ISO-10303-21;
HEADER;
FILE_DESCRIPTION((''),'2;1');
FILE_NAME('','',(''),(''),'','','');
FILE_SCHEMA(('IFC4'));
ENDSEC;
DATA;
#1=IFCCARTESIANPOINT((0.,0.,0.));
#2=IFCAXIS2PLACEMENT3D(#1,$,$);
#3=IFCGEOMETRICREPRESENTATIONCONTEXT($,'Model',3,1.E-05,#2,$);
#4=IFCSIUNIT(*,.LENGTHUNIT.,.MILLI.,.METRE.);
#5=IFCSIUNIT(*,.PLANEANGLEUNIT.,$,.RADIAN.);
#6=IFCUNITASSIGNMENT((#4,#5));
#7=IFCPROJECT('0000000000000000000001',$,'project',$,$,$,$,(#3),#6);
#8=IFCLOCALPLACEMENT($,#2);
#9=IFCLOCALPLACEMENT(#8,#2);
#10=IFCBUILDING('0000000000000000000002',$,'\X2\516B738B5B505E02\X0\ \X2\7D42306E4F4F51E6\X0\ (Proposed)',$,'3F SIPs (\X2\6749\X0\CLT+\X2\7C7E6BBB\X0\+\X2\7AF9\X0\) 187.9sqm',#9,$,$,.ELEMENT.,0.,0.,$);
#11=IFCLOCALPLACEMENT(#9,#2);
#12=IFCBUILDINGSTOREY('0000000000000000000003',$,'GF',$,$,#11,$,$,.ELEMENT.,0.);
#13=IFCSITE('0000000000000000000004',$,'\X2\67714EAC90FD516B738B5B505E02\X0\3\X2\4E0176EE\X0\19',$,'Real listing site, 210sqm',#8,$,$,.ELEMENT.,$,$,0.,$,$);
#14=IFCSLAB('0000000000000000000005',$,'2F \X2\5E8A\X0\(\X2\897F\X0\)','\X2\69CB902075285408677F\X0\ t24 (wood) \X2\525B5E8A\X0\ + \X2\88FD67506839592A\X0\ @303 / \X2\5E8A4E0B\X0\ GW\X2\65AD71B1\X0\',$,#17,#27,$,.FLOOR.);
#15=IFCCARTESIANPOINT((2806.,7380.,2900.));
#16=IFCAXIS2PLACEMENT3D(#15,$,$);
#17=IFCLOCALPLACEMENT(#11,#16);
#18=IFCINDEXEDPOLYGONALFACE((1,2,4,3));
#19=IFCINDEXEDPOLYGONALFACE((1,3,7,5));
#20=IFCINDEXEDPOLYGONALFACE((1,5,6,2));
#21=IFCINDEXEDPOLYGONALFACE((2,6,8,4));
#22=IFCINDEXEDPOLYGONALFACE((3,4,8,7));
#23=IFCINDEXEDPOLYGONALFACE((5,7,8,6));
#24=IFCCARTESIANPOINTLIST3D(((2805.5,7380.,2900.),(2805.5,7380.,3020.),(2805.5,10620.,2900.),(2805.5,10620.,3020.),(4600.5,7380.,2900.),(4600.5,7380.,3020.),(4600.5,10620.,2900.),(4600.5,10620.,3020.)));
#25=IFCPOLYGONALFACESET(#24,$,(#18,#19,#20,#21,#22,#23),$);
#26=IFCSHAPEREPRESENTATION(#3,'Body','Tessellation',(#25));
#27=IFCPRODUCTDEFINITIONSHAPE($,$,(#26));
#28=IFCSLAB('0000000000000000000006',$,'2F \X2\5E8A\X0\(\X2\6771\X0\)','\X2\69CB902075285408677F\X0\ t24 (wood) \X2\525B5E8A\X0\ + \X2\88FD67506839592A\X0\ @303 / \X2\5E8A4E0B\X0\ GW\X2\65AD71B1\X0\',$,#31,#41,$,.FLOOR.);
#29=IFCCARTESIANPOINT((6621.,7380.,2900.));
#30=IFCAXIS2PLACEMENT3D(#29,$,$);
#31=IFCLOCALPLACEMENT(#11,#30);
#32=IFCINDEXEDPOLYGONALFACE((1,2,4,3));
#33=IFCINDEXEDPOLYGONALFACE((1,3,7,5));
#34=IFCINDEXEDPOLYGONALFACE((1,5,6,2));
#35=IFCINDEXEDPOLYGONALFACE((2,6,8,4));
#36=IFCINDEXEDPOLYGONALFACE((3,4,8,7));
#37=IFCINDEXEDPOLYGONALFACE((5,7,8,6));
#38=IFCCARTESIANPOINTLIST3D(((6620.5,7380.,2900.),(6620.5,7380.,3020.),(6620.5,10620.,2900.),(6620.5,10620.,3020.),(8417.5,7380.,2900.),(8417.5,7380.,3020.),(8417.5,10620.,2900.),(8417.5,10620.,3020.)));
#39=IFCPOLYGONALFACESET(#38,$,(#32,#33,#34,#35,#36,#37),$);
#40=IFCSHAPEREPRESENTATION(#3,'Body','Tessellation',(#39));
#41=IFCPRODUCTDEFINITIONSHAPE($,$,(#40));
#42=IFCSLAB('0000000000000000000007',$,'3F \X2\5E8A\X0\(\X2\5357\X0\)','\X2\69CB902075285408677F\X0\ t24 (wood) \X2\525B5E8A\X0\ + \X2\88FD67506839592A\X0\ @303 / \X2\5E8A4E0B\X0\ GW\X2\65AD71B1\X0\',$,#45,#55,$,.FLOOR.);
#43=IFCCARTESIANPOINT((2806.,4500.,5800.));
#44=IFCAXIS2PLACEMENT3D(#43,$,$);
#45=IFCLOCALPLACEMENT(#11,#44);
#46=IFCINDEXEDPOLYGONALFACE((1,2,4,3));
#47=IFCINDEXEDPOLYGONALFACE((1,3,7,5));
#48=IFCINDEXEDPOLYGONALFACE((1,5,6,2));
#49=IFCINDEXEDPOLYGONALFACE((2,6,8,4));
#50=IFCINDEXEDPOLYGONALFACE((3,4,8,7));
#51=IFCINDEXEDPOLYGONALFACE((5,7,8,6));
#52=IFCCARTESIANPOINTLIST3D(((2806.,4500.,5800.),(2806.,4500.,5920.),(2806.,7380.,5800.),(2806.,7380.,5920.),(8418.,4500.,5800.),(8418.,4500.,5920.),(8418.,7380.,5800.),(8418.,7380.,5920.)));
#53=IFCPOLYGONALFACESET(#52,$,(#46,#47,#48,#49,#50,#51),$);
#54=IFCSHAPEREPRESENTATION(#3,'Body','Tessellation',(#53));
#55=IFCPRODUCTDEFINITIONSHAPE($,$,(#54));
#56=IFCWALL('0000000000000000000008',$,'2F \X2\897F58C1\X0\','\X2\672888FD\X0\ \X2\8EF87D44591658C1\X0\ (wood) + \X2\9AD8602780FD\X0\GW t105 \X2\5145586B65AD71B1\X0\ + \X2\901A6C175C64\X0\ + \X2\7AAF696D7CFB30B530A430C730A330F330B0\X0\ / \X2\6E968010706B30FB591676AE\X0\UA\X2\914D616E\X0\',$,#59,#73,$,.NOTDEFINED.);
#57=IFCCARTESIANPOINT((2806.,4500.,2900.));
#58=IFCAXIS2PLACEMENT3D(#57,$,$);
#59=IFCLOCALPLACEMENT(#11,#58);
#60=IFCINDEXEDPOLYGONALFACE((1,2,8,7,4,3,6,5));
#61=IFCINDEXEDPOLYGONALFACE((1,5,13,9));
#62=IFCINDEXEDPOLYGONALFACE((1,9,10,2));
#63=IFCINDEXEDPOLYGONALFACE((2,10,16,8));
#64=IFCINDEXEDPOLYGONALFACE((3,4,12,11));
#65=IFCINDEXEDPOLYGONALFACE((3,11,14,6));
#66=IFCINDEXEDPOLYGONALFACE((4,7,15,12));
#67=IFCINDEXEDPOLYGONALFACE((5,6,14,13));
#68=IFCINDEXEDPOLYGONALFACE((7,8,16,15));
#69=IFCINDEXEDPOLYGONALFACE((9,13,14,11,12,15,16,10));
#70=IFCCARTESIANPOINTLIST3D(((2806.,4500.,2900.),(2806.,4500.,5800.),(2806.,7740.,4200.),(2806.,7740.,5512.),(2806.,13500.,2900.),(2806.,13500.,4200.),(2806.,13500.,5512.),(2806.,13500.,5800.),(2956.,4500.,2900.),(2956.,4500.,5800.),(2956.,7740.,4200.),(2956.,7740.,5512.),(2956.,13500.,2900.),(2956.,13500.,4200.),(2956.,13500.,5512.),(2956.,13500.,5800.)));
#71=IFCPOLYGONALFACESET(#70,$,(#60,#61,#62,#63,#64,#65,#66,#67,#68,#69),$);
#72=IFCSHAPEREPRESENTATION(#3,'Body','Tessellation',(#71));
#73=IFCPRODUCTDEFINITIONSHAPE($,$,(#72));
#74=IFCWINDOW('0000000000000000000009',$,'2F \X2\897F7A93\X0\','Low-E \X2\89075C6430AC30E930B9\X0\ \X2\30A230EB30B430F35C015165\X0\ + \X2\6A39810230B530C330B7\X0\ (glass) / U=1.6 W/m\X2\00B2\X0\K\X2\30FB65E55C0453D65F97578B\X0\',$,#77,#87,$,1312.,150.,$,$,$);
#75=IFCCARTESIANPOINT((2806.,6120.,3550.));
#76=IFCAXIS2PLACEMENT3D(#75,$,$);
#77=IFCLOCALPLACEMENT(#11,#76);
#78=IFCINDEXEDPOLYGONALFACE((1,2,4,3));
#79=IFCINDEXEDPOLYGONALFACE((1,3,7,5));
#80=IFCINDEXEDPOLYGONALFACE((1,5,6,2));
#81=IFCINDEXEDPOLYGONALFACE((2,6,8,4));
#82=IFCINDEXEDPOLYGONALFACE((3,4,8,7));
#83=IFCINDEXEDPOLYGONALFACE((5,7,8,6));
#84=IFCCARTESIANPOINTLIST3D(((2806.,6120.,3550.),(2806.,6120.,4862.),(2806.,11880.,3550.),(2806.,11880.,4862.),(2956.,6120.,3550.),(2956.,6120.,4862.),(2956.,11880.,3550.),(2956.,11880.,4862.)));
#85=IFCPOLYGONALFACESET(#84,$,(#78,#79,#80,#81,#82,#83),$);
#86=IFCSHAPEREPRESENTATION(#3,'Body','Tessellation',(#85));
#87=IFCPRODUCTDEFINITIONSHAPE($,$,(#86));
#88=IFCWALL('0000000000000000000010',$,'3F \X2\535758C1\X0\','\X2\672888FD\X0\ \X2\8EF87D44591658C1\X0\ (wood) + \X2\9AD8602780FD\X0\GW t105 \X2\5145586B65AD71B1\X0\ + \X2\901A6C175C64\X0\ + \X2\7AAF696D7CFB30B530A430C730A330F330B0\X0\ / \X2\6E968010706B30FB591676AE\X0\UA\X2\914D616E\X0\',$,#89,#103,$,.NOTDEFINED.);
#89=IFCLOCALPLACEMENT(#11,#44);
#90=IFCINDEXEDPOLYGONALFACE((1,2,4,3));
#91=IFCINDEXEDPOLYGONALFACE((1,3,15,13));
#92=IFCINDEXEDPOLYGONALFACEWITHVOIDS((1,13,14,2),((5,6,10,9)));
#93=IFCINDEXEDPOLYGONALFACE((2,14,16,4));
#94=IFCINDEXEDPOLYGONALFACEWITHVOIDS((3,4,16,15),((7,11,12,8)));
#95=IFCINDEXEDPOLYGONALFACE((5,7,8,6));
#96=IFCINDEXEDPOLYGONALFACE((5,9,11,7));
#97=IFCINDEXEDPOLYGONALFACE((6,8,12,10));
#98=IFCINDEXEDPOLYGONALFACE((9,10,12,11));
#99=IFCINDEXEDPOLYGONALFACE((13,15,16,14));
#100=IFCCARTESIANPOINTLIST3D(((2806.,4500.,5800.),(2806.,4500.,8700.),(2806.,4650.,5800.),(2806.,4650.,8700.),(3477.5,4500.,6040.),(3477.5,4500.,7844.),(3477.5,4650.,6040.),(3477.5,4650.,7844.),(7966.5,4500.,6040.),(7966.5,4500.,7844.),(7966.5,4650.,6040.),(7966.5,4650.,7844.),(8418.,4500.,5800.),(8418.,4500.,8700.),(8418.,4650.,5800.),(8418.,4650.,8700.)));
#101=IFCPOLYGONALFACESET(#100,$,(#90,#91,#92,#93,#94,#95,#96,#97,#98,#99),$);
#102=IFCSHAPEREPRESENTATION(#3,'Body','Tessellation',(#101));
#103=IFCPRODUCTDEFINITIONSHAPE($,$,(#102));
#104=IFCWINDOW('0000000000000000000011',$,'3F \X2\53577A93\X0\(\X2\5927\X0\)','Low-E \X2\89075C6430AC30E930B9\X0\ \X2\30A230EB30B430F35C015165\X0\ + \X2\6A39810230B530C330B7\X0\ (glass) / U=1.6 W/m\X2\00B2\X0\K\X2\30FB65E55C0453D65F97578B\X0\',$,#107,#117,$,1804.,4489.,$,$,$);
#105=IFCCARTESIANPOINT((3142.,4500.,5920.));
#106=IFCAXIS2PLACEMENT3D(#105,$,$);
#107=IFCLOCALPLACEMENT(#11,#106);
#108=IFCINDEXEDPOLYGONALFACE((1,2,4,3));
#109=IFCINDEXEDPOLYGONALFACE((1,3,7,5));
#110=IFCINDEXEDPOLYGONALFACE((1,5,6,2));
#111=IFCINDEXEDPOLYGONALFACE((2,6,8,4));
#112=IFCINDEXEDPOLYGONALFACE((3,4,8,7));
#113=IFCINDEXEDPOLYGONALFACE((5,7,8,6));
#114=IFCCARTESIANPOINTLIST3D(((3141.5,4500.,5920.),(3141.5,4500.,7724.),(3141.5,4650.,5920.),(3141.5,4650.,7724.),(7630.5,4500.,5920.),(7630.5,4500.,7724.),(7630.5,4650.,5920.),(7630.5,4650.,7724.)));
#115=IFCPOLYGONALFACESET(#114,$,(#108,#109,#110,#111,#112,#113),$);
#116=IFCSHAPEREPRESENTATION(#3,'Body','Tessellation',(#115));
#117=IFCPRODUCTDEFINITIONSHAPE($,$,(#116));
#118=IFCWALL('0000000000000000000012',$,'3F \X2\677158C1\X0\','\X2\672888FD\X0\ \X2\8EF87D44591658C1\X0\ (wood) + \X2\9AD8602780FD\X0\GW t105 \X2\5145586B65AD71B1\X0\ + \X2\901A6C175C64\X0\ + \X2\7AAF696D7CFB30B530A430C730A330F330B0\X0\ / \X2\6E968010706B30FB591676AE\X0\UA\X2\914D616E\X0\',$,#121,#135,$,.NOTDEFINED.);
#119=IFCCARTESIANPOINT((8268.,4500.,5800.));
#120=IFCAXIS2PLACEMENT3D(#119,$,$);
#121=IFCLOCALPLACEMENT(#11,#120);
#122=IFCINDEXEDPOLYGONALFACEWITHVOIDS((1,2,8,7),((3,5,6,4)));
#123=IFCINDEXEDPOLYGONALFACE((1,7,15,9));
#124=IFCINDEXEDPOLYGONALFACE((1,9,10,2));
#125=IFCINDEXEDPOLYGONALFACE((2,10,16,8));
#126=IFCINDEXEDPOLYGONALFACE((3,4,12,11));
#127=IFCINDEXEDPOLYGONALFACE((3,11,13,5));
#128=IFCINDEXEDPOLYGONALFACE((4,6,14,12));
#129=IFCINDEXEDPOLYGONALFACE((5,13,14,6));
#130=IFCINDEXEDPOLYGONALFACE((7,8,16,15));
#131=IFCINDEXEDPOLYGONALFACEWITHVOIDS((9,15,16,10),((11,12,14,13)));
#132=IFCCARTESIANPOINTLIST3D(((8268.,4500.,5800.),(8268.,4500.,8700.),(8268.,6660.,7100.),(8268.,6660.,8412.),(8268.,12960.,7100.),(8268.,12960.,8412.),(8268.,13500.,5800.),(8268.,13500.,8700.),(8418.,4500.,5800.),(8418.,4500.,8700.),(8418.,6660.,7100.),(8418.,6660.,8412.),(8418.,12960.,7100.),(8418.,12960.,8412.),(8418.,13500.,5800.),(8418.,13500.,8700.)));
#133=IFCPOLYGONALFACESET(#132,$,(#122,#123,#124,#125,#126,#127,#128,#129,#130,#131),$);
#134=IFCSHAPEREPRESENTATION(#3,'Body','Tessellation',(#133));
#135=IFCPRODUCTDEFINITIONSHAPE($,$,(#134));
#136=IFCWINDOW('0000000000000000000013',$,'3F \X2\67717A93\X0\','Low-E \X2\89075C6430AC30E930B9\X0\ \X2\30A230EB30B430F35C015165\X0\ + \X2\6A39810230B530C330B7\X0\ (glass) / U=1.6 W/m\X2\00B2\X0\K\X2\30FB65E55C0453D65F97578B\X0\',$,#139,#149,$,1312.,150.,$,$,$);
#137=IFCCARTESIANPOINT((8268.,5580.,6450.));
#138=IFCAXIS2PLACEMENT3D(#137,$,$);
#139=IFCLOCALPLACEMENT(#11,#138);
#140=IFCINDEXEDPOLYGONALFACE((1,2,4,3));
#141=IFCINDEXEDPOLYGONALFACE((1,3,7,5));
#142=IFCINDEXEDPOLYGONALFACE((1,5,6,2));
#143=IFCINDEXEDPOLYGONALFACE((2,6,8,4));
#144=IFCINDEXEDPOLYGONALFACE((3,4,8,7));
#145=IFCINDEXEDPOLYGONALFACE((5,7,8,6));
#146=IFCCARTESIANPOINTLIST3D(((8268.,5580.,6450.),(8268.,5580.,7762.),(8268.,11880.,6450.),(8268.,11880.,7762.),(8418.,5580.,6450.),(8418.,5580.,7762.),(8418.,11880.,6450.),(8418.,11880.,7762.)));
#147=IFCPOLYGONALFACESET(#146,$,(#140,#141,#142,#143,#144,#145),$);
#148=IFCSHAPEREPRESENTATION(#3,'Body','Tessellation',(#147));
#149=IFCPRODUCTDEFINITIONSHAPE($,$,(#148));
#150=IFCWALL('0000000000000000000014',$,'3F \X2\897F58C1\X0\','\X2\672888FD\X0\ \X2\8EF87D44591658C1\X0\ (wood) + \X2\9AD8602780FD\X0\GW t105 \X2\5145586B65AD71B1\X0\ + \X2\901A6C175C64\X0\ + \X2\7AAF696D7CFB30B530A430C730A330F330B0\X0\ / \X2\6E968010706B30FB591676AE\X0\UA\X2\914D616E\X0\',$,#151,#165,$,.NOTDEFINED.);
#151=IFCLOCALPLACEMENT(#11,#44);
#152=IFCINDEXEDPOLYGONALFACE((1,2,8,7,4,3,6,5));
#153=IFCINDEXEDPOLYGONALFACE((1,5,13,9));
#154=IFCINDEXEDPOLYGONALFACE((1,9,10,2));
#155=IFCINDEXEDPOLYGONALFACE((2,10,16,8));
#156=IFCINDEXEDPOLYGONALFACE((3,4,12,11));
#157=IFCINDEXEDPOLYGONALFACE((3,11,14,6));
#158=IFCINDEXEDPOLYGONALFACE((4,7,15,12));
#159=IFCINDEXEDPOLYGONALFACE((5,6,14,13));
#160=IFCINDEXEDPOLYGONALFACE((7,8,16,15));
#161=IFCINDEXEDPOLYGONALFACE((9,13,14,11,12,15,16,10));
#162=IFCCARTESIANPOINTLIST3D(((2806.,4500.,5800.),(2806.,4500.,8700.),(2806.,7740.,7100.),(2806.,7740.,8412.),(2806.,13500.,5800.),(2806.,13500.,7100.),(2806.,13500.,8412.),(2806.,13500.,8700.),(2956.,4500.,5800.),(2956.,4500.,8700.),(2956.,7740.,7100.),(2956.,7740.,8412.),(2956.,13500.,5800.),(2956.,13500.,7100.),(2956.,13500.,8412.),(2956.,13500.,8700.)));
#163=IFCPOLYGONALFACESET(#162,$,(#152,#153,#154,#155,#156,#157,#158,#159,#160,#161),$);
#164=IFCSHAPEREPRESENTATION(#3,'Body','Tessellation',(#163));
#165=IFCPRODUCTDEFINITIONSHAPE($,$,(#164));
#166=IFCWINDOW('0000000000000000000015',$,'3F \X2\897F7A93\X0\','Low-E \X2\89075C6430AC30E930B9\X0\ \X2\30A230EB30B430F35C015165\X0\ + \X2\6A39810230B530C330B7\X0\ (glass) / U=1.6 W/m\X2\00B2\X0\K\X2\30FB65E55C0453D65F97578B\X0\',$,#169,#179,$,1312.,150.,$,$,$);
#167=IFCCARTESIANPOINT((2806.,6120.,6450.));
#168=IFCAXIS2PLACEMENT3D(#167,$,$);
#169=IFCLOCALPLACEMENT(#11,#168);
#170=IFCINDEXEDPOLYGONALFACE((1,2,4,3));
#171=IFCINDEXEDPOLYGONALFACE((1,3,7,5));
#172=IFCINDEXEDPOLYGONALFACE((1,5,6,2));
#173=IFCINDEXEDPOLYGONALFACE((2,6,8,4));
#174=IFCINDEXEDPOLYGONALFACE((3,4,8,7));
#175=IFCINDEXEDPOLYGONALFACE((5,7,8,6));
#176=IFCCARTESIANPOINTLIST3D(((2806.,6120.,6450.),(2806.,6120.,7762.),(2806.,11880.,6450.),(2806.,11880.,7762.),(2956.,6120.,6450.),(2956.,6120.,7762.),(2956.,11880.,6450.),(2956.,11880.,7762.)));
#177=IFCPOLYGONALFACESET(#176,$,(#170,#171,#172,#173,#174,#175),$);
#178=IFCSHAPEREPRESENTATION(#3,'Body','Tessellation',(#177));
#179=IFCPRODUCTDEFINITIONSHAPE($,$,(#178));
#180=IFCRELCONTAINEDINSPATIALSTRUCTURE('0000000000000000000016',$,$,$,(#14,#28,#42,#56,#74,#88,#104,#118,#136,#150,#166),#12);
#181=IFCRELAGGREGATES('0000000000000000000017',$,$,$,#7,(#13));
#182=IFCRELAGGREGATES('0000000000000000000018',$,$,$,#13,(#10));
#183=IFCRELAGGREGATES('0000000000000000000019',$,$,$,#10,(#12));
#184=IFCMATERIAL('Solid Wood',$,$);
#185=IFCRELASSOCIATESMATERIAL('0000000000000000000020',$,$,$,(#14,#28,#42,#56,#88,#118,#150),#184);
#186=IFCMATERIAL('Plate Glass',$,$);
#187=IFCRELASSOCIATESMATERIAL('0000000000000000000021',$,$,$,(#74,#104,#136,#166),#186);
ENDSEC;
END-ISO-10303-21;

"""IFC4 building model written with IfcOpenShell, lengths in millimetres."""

from ifc_helpers import new_model, si_unit, frame, frame_2d, origin, place, context, project, spatial, rectangle, extrude, material, element, fill, save


model = new_model("IFC4")

# Units and contexts
model_context = context("Model", 3, precision=1e-05, world=origin())
ifc_project = project(units=[si_unit("LENGTHUNIT", "METRE", prefix="MILLI"), si_unit("PLANEANGLEUNIT", "RADIAN")], contexts=[model_context])

# Site, building, storey
site_placement = place(None, origin())
site = spatial("IfcSite", under=ifc_project, at=site_placement, Name="東京都八王子市3丁目19", ObjectType="Real listing site, 210sqm", CompositionType="ELEMENT", RefElevation=0.0)
building_placement = place(site_placement, origin())
building = spatial("IfcBuilding", under=site, at=building_placement, Name="八王子市 終の住処 (Proposed)", ObjectType="3F SIPs (杉CLT+籾殻+竹) 187.9sqm", CompositionType="ELEMENT", ElevationOfRefHeight=0.0, ElevationOfTerrain=0.0)
storey_placement = place(building_placement, origin())
storey = spatial("IfcBuildingStorey", under=building, at=storey_placement, Name="GF", CompositionType="ELEMENT", Elevation=0.0)

# Slabs
ifc_material_1 = material(Name="Solid Wood")
slab_1_placement = place(storey_placement, frame((2806.0, 7380.0, 2900.0)))
element("IfcSlab", 1, at=slab_1_placement, inside=storey, material=ifc_material_1, Name="2F 床(西)", Description="構造用合板 t24 (wood) 剛床 + 製材根太 @303 / 床下 GW断熱", PredefinedType="FLOOR", context=model_context, shape_type="SweptSolid", body=[
    extrude(rectangle(XDim=1795.0, YDim=3240.0, at=frame_2d((897.0, 1620.0))), frame((2806.0, 7380.0, 2900.0)), (0.0, 0.0, 1.0), 120.0),
])
slab_2_placement = place(storey_placement, frame((6621.0, 7380.0, 2900.0)))
element("IfcSlab", 2, at=slab_2_placement, inside=storey, material=ifc_material_1, Name="2F 床(東)", Description="構造用合板 t24 (wood) 剛床 + 製材根太 @303 / 床下 GW断熱", PredefinedType="FLOOR", context=model_context, shape_type="SweptSolid", body=[
    extrude(rectangle(XDim=1797.0, YDim=3240.0, at=frame_2d((898.0, 1620.0))), frame((6621.0, 7380.0, 2900.0)), (0.0, 0.0, 1.0), 120.0),
])
slab_3_placement = place(storey_placement, frame((2806.0, 4500.0, 5800.0)))
element("IfcSlab", 3, at=slab_3_placement, inside=storey, material=ifc_material_1, Name="3F 床(南)", Description="構造用合板 t24 (wood) 剛床 + 製材根太 @303 / 床下 GW断熱", PredefinedType="FLOOR", context=model_context, shape_type="SweptSolid", body=[
    extrude(rectangle(XDim=5612.0, YDim=2880.0, at=frame_2d((2806.0, 1440.0))), frame((2806.0, 4500.0, 5800.0)), (0.0, 0.0, 1.0), 120.0),
])

# Walls, openings, windows
wall_1_placement = place(storey_placement, frame((2806.0, 4500.0, 2900.0)))
wall_1 = element("IfcWall", 4, at=wall_1_placement, inside=storey, material=ifc_material_1, Name="2F 西壁", Description="木製 軸組外壁 (wood) + 高性能GW t105 充填断熱 + 通気層 + 窯業系サイディング / 準耐火・外皮UA配慮", PredefinedType="NOTDEFINED", context=model_context, shape_type="SweptSolid", body=[
    extrude(rectangle(XDim=150.0, YDim=9000.0, at=frame_2d((75.0, 4500.0))), frame((2806.0, 4500.0, 2900.0)), (0.0, 0.0, 1.0), 2900.0),
])
opening_1_placement = place(storey_placement, frame((2806.0, 6120.0, 3550.0)))
opening_1 = element("IfcOpeningElement", 5, at=opening_1_placement, cuts=wall_1, PredefinedType="NOTDEFINED", context=model_context, shape_type="SweptSolid", body=[
    extrude(rectangle(XDim=150.0, YDim=5760.0, at=frame_2d((75.0, 2880.0))), frame((2806.0, 6120.0, 3550.0)), (0.0, 0.0, 1.0), 1312.0),
])
ifc_material_2 = material(Name="Plate Glass")
window_1_placement = place(storey_placement, frame((2806.0, 6120.0, 3550.0)))
window_1 = element("IfcWindow", 6, at=window_1_placement, inside=storey, material=ifc_material_2, Name="2F 西窓", Description="Low-E 複層ガラス アルゴン封入 + 樹脂サッシ (glass) / U=1.6 W/m²K・日射取得型", OverallHeight=1312.0, OverallWidth=150.0, context=model_context, shape_type="SweptSolid", body=[
    extrude(rectangle(XDim=150.0, YDim=5760.0, at=frame_2d((75.0, 2880.0))), frame((2806.0, 6120.0, 3550.0)), (0.0, 0.0, 1.0), 1312.0),
])
fill(opening_1, window_1)
wall_2_placement = place(storey_placement, frame((2806.0, 4500.0, 5800.0)))
wall_2 = element("IfcWall", 7, at=wall_2_placement, inside=storey, material=ifc_material_1, Name="3F 南壁", Description="木製 軸組外壁 (wood) + 高性能GW t105 充填断熱 + 通気層 + 窯業系サイディング / 準耐火・外皮UA配慮", PredefinedType="NOTDEFINED", context=model_context, shape_type="SweptSolid", body=[
    extrude(rectangle(XDim=5612.0, YDim=150.0, at=frame_2d((2806.0, 75.0))), frame((2806.0, 4500.0, 5800.0)), (0.0, 0.0, 1.0), 2900.0),
])
opening_2_placement = place(storey_placement, frame((3142.0, 4500.0, 5920.0)))
opening_2 = element("IfcOpeningElement", 8, at=opening_2_placement, cuts=wall_2, PredefinedType="NOTDEFINED", context=model_context, shape_type="SweptSolid", body=[
    extrude(rectangle(XDim=4489.0, YDim=150.0, at=frame_2d((2244.0, 75.0))), frame((3142.0, 4500.0, 5920.0)), (0.0, 0.0, 1.0), 1804.0),
])
window_2_placement = place(storey_placement, frame((3142.0, 4500.0, 5920.0)))
window_2 = element("IfcWindow", 9, at=window_2_placement, inside=storey, material=ifc_material_2, Name="3F 南窓(大)", Description="Low-E 複層ガラス アルゴン封入 + 樹脂サッシ (glass) / U=1.6 W/m²K・日射取得型", OverallHeight=1804.0, OverallWidth=4489.0, context=model_context, shape_type="SweptSolid", body=[
    extrude(rectangle(XDim=4489.0, YDim=150.0, at=frame_2d((2244.0, 75.0))), frame((3142.0, 4500.0, 5920.0)), (0.0, 0.0, 1.0), 1804.0),
])
fill(opening_2, window_2)
wall_3_placement = place(storey_placement, frame((8268.0, 4500.0, 5800.0)))
wall_3 = element("IfcWall", 10, at=wall_3_placement, inside=storey, material=ifc_material_1, Name="3F 東壁", Description="木製 軸組外壁 (wood) + 高性能GW t105 充填断熱 + 通気層 + 窯業系サイディング / 準耐火・外皮UA配慮", PredefinedType="NOTDEFINED", context=model_context, shape_type="SweptSolid", body=[
    extrude(rectangle(XDim=150.0, YDim=9000.0, at=frame_2d((75.0, 4500.0))), frame((8268.0, 4500.0, 5800.0)), (0.0, 0.0, 1.0), 2900.0),
])
opening_3_placement = place(storey_placement, frame((8268.0, 5580.0, 6450.0)))
opening_3 = element("IfcOpeningElement", 11, at=opening_3_placement, cuts=wall_3, PredefinedType="NOTDEFINED", context=model_context, shape_type="SweptSolid", body=[
    extrude(rectangle(XDim=150.0, YDim=6300.0, at=frame_2d((75.0, 3150.0))), frame((8268.0, 5580.0, 6450.0)), (0.0, 0.0, 1.0), 1312.0),
])
window_3_placement = place(storey_placement, frame((8268.0, 5580.0, 6450.0)))
window_3 = element("IfcWindow", 12, at=window_3_placement, inside=storey, material=ifc_material_2, Name="3F 東窓", Description="Low-E 複層ガラス アルゴン封入 + 樹脂サッシ (glass) / U=1.6 W/m²K・日射取得型", OverallHeight=1312.0, OverallWidth=150.0, context=model_context, shape_type="SweptSolid", body=[
    extrude(rectangle(XDim=150.0, YDim=6300.0, at=frame_2d((75.0, 3150.0))), frame((8268.0, 5580.0, 6450.0)), (0.0, 0.0, 1.0), 1312.0),
])
fill(opening_3, window_3)
wall_4_placement = place(storey_placement, frame((2806.0, 4500.0, 5800.0)))
wall_4 = element("IfcWall", 13, at=wall_4_placement, inside=storey, material=ifc_material_1, Name="3F 西壁", Description="木製 軸組外壁 (wood) + 高性能GW t105 充填断熱 + 通気層 + 窯業系サイディング / 準耐火・外皮UA配慮", PredefinedType="NOTDEFINED", context=model_context, shape_type="SweptSolid", body=[
    extrude(rectangle(XDim=150.0, YDim=9000.0, at=frame_2d((75.0, 4500.0))), frame((2806.0, 4500.0, 5800.0)), (0.0, 0.0, 1.0), 2900.0),
])
opening_4_placement = place(storey_placement, frame((2806.0, 6120.0, 6450.0)))
opening_4 = element("IfcOpeningElement", 14, at=opening_4_placement, cuts=wall_4, PredefinedType="NOTDEFINED", context=model_context, shape_type="SweptSolid", body=[
    extrude(rectangle(XDim=150.0, YDim=5760.0, at=frame_2d((75.0, 2880.0))), frame((2806.0, 6120.0, 6450.0)), (0.0, 0.0, 1.0), 1312.0),
])
window_4_placement = place(storey_placement, frame((2806.0, 6120.0, 6450.0)))
window_4 = element("IfcWindow", 15, at=window_4_placement, inside=storey, material=ifc_material_2, Name="3F 西窓", Description="Low-E 複層ガラス アルゴン封入 + 樹脂サッシ (glass) / U=1.6 W/m²K・日射取得型", OverallHeight=1312.0, OverallWidth=150.0, context=model_context, shape_type="SweptSolid", body=[
    extrude(rectangle(XDim=150.0, YDim=5760.0, at=frame_2d((75.0, 2880.0))), frame((2806.0, 6120.0, 6450.0)), (0.0, 0.0, 1.0), 1312.0),
])
fill(opening_4, window_4)

save(model, "model.ifc")
